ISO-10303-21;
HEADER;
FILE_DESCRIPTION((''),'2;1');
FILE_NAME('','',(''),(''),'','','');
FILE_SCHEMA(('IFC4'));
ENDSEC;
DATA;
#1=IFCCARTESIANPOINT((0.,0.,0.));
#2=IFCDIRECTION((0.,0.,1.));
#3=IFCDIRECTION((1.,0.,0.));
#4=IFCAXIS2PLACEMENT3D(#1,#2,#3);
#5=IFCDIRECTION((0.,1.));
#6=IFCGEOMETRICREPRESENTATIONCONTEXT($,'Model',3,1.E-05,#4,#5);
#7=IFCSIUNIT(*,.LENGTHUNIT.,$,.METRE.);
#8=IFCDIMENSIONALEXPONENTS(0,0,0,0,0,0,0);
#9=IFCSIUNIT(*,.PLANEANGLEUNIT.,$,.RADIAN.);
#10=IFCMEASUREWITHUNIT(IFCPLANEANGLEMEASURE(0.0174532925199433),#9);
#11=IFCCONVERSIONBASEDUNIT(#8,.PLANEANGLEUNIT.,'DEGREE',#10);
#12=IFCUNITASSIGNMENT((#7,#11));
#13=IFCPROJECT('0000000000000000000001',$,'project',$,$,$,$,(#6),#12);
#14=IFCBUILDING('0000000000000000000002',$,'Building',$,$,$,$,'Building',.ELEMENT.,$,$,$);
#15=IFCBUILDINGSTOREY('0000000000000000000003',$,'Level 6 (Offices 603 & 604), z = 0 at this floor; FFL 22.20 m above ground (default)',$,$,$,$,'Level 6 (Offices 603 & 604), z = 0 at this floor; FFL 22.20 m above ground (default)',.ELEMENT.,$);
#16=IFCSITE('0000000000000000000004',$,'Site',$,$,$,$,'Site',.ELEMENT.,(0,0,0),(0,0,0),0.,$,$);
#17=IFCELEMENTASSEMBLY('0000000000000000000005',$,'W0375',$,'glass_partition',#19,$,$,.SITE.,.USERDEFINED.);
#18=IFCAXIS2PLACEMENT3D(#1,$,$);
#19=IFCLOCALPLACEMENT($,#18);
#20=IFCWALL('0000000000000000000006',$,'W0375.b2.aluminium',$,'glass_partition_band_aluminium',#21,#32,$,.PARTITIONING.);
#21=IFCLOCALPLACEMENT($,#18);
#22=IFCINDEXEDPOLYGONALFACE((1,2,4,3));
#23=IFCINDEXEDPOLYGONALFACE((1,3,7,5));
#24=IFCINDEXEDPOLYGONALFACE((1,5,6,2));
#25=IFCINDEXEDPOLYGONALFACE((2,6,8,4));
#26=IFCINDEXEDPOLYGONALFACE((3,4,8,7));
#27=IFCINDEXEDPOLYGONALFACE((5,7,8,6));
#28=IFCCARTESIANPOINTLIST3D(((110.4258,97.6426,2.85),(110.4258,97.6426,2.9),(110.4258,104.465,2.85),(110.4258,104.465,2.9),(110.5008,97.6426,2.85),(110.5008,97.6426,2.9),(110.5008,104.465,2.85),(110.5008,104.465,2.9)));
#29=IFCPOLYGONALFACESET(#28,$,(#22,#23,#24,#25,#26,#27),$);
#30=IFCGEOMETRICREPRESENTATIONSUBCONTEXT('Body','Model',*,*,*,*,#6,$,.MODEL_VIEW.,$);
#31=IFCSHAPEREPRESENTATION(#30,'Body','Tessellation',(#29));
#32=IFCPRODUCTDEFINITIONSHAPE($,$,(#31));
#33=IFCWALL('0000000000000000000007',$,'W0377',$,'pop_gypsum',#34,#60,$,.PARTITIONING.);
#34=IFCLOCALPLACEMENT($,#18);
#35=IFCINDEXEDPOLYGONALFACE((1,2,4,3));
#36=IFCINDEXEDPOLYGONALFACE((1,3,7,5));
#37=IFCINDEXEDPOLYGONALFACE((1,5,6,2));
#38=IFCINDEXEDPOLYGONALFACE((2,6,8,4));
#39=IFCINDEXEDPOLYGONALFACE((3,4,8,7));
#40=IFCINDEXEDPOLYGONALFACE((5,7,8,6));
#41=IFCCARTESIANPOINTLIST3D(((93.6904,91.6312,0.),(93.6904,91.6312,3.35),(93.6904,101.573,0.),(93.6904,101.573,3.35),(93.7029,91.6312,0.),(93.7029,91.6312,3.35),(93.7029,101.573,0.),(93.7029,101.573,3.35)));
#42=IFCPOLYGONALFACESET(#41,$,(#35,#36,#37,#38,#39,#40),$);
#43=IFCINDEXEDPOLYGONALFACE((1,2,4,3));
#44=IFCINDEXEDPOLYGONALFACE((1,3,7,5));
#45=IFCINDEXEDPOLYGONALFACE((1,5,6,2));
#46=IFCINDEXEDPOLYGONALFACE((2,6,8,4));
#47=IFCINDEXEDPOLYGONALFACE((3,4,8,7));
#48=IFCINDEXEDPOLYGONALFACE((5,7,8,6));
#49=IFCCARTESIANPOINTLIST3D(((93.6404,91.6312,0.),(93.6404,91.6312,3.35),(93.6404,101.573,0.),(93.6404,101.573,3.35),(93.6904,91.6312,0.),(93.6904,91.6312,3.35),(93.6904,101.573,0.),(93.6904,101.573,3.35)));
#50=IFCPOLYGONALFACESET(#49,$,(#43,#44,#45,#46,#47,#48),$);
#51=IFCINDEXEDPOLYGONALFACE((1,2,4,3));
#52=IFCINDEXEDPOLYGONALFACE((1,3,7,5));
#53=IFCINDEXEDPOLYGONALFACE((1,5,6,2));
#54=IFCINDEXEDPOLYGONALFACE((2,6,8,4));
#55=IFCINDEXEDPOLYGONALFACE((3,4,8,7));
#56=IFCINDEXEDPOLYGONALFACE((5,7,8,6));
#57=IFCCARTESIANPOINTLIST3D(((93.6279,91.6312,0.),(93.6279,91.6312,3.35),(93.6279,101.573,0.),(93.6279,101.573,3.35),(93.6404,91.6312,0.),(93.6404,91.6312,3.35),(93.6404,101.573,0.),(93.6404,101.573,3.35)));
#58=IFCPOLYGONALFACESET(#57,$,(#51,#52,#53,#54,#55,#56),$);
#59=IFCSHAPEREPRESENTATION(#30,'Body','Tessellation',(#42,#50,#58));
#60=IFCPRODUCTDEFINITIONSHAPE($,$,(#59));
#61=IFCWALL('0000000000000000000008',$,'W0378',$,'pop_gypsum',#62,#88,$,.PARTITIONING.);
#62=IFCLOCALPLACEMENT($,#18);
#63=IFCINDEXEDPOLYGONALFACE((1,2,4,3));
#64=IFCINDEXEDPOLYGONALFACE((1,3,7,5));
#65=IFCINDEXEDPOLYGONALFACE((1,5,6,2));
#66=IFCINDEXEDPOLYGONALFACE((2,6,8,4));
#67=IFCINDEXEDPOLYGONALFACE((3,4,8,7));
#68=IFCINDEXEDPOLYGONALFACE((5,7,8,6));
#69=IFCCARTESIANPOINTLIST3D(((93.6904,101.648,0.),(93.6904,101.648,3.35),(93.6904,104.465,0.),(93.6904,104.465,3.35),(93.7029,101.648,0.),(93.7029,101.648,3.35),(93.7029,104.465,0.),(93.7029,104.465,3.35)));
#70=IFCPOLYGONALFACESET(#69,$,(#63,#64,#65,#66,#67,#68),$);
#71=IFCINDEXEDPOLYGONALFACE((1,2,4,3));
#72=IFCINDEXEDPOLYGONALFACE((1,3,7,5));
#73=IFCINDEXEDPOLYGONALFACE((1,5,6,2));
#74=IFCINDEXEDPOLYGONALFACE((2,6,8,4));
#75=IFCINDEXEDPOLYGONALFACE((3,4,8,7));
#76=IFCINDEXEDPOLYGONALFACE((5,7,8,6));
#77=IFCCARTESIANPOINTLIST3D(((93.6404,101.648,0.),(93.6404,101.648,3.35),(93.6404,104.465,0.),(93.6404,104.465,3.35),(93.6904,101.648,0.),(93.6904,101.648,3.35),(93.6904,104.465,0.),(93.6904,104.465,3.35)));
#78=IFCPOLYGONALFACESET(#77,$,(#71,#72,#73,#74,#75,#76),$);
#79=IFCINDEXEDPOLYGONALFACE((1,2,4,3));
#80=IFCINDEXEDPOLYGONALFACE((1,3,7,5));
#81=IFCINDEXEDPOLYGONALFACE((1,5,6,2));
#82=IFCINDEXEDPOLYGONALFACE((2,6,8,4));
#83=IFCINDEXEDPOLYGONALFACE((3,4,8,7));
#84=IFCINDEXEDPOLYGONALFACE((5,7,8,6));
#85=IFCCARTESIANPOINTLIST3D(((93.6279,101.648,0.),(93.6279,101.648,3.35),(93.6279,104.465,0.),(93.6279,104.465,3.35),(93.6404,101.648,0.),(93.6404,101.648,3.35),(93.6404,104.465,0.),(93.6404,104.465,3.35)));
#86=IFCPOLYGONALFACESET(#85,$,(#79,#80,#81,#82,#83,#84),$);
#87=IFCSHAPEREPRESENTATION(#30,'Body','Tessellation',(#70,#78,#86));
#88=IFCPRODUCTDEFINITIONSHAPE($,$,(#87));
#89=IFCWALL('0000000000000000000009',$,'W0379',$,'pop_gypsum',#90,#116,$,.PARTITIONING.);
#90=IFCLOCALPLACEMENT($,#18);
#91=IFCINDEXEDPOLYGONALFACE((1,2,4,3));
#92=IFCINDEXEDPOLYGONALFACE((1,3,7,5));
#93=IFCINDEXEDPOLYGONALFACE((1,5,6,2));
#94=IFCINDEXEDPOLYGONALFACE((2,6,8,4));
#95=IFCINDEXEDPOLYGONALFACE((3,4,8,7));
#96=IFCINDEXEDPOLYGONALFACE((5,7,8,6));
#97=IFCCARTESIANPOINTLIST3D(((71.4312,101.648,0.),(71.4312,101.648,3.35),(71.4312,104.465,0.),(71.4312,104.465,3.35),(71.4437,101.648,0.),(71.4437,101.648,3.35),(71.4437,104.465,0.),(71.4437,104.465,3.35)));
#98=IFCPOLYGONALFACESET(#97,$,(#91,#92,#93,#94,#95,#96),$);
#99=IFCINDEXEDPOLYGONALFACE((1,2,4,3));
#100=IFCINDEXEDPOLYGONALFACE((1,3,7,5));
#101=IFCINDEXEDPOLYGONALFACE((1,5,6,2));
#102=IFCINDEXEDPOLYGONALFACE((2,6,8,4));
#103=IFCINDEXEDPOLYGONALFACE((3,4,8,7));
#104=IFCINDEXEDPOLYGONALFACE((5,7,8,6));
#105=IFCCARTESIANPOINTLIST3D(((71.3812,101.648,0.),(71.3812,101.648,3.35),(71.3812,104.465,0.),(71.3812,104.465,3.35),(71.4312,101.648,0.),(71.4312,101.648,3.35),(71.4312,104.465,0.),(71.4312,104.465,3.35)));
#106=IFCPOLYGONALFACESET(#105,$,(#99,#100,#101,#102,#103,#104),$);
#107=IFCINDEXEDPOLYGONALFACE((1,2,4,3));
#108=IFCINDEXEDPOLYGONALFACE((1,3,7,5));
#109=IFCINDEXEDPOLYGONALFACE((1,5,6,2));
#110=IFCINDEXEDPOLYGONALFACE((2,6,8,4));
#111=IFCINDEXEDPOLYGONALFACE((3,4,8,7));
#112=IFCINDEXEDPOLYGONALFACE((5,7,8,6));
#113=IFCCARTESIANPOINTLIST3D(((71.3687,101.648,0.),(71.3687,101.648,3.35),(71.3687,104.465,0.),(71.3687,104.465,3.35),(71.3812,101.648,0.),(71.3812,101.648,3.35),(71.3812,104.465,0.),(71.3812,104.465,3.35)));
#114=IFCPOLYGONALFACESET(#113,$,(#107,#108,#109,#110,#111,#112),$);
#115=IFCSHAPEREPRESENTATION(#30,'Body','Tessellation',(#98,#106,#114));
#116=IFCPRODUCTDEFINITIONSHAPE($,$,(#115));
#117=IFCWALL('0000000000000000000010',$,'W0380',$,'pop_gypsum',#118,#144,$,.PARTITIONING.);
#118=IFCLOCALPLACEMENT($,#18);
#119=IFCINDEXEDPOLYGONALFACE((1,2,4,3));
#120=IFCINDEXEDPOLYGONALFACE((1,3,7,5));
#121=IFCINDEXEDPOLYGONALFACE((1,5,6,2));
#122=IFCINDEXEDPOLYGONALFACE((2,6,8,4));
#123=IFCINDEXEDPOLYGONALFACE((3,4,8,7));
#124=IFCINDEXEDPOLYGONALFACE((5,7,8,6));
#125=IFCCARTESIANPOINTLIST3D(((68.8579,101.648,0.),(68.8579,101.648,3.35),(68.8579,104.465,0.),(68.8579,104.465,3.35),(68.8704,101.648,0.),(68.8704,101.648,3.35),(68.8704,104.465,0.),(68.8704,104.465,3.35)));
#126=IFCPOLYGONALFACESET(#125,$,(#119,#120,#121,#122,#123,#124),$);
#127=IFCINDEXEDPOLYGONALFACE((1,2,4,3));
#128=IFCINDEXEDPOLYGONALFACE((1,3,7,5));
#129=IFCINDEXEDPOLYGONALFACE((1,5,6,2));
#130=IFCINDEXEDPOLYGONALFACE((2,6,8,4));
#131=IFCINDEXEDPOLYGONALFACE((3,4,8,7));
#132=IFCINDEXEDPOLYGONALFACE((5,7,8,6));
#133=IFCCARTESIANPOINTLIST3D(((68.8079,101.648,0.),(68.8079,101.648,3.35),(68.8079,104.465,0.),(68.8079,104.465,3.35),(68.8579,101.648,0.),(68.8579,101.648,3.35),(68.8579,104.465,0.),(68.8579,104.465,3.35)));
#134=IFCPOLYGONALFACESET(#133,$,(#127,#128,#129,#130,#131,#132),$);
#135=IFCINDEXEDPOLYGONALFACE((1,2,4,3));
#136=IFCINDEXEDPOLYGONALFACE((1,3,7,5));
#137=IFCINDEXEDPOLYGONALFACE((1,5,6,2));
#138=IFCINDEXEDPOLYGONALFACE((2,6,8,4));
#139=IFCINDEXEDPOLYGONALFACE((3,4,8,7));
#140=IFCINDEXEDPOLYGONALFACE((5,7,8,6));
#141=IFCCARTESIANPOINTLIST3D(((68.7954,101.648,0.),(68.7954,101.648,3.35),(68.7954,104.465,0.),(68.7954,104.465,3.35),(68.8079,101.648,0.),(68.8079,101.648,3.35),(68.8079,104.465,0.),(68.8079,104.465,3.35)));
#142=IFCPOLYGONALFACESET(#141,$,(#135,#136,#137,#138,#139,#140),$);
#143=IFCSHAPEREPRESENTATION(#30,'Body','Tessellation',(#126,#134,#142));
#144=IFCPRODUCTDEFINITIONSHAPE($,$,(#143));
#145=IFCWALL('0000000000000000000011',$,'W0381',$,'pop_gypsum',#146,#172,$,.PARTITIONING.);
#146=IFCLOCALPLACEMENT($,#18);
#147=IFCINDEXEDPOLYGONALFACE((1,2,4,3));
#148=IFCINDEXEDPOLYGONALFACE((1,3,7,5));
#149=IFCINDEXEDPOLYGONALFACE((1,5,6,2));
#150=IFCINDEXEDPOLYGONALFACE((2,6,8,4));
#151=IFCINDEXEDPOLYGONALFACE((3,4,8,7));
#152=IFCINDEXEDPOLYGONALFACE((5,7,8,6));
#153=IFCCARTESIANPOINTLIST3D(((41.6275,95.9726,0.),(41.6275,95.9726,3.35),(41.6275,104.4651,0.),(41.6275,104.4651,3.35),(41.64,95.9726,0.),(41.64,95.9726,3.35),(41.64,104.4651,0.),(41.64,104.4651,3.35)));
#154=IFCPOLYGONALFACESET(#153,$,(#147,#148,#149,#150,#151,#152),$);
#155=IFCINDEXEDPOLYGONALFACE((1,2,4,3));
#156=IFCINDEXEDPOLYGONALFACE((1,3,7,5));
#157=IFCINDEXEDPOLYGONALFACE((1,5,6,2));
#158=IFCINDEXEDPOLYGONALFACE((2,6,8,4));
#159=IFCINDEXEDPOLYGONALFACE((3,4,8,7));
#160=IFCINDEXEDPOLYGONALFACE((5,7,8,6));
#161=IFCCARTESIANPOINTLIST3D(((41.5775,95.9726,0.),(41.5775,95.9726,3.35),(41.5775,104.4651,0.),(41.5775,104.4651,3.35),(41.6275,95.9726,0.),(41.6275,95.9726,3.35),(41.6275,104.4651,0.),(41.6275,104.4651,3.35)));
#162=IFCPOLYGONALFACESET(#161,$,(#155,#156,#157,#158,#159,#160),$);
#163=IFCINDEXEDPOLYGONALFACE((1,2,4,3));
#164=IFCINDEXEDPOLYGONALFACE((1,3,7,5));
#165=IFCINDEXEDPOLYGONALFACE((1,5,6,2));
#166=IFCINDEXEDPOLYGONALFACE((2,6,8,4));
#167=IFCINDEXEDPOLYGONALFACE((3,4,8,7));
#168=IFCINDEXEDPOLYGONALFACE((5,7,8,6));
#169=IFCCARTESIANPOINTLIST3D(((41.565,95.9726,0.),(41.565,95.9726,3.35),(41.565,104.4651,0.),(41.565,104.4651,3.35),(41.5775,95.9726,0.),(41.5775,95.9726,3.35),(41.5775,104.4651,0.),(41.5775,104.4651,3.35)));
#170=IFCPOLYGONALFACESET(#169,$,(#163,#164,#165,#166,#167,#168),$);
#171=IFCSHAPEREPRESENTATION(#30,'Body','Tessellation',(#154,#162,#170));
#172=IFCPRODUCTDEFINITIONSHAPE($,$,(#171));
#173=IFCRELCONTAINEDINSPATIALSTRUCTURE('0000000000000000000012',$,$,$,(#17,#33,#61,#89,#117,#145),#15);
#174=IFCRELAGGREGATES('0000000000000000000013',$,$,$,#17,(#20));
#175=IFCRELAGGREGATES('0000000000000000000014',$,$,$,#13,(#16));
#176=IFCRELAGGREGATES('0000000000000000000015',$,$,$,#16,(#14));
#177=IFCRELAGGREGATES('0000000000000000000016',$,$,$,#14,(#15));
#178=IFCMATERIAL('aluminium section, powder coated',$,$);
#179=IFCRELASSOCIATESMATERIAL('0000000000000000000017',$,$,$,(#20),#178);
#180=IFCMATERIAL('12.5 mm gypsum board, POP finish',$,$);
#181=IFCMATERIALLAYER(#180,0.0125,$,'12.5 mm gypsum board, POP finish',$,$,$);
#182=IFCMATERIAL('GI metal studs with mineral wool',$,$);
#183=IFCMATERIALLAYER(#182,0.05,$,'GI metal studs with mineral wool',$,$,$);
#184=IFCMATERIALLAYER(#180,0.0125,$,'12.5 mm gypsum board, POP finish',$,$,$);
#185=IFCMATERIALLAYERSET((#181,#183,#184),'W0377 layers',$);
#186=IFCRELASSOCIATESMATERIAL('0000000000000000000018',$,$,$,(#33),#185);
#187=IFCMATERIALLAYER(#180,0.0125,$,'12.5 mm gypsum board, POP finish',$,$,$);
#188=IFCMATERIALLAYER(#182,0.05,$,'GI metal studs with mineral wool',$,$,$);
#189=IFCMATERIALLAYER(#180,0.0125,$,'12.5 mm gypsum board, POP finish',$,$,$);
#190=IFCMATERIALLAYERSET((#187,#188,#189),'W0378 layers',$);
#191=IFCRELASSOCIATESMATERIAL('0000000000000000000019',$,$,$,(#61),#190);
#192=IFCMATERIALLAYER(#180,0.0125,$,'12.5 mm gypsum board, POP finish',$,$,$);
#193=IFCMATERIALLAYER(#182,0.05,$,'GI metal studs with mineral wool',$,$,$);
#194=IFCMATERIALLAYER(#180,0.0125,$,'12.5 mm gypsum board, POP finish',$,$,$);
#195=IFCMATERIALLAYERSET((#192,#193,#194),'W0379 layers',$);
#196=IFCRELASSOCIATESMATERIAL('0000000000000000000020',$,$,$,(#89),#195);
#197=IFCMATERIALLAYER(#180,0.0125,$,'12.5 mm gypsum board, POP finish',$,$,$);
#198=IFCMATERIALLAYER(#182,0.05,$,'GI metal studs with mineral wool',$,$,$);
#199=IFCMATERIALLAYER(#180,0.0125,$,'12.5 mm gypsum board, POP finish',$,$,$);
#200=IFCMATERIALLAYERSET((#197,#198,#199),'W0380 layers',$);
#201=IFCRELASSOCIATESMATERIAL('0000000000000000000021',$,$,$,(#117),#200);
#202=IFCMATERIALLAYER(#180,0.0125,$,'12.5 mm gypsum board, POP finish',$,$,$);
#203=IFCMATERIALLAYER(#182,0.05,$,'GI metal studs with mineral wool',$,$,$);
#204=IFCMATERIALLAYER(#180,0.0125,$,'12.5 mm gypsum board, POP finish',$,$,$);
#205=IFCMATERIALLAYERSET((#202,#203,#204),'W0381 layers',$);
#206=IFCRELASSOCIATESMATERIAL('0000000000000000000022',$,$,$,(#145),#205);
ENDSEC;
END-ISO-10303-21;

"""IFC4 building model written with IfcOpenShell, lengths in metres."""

from ifc_helpers import new_model, entity, si_unit, converted_unit, direction, frame, frame_2d, origin_with_axes, place, context, subcontext, project, spatial, rectangle, extrude, material, layer, layer_set, layer_usage, element, aggregate, save


model = new_model("IFC4")

# Units and contexts
model_context = context("Model", 3, precision=1e-05, world=origin_with_axes(), true_north=direction((0.0, 1.0)))
body_context = subcontext(model_context, "Body", "Model", "MODEL_VIEW")
ifc_project = project(units=[si_unit("LENGTHUNIT", "METRE"), converted_unit("PLANEANGLEUNIT", "DEGREE", entity("IfcPlaneAngleMeasure", 0.0174532925199433), si_unit("PLANEANGLEUNIT", "RADIAN"), dimensions=[0, 0, 0, 0, 0, 0, 0])], contexts=[model_context])

# Site, building, storey
site = spatial("IfcSite", under=ifc_project, Name="Site", LongName="Site", CompositionType="ELEMENT", RefLatitude=(0, 0, 0), RefLongitude=(0, 0, 0), RefElevation=0.0)
building = spatial("IfcBuilding", under=site, Name="Building", LongName="Building", CompositionType="ELEMENT")
storey = spatial("IfcBuildingStorey", under=building, Name="Level 6 (Offices 603 & 604), z = 0 at this floor; FFL 22.20 m above ground (default)", LongName="Level 6 (Offices 603 & 604), z = 0 at this floor; FFL 22.20 m above ground (default)", CompositionType="ELEMENT")

# Element assembly, wall
assembly_1 = element("IfcElementAssembly", 1, inside=storey, Name="W0375", ObjectType="glass_partition", AssemblyPlace="SITE", PredefinedType="USERDEFINED")
ifc_material_1 = material(Name="aluminium section, powder coated")
placement = place(None, origin_with_axes())
wall_1 = element("IfcWall", 2, at=placement, material=ifc_material_1, Name="W0375.b2.aluminium", ObjectType="glass_partition_band_aluminium", PredefinedType="PARTITIONING", context=body_context, shape_type="SweptSolid", body=[
    extrude(rectangle(XDim=6.8224, YDim=0.075, at=frame_2d((0.0, 0.0), x_axis=(0.0, 1.0))), frame((110.4633, 101.0538, 2.85), z_axis=(0.0, 0.0, 1.0), x_axis=(1.0, 0.0, 0.0)), (0.0, 0.0, 1.0), 0.05),
])
aggregate(assembly_1, [wall_1])

# Walls
ifc_material_2 = material(Name="12.5 mm gypsum board, POP finish")
ifc_layer_1 = layer(ifc_material_2, 0.0125, Name="12.5 mm gypsum board, POP finish")
ifc_material_3 = material(Name="GI metal studs with mineral wool")
ifc_layer_2 = layer(ifc_material_3, 0.05, Name="GI metal studs with mineral wool")
ifc_layer_3 = layer(ifc_material_2, 0.0125, Name="12.5 mm gypsum board, POP finish")
ifc_layer_set_1 = layer_set([ifc_layer_1, ifc_layer_2, ifc_layer_3], Name="W0377 layers")
ifc_layer_usage_1 = layer_usage(ifc_layer_set_1, "AXIS2", "POSITIVE", -0.0375)
element("IfcWall", 3, at=placement, inside=storey, material=ifc_layer_usage_1, Name="W0377", ObjectType="pop_gypsum", PredefinedType="PARTITIONING", context=body_context, shape_type="SweptSolid", body=[
    extrude(rectangle(XDim=9.9418, YDim=0.0125, at=frame_2d((0.0, 0.0), x_axis=(0.0, 1.0))), frame((93.6967, 96.6021, 0.0), z_axis=(0.0, 0.0, 1.0), x_axis=(1.0, 0.0, 0.0)), (0.0, 0.0, 1.0), 3.35),
    extrude(rectangle(XDim=9.9418, YDim=0.05, at=frame_2d((-0.0312, 0.0), x_axis=(0.0, 1.0))), frame((93.6967, 96.6021, 0.0), z_axis=(0.0, 0.0, 1.0), x_axis=(1.0, 0.0, 0.0)), (0.0, 0.0, 1.0), 3.35),
    extrude(rectangle(XDim=9.9418, YDim=0.0125, at=frame_2d((-0.0625, 0.0), x_axis=(0.0, 1.0))), frame((93.6967, 96.6021, 0.0), z_axis=(0.0, 0.0, 1.0), x_axis=(1.0, 0.0, 0.0)), (0.0, 0.0, 1.0), 3.35),
])
ifc_layer_4 = layer(ifc_material_2, 0.0125, Name="12.5 mm gypsum board, POP finish")
ifc_layer_5 = layer(ifc_material_3, 0.05, Name="GI metal studs with mineral wool")
ifc_layer_6 = layer(ifc_material_2, 0.0125, Name="12.5 mm gypsum board, POP finish")
ifc_layer_set_2 = layer_set([ifc_layer_4, ifc_layer_5, ifc_layer_6], Name="W0378 layers")
ifc_layer_usage_2 = layer_usage(ifc_layer_set_2, "AXIS2", "POSITIVE", -0.0375)
element("IfcWall", 4, at=placement, inside=storey, material=ifc_layer_usage_2, Name="W0378", ObjectType="pop_gypsum", PredefinedType="PARTITIONING", context=body_context, shape_type="SweptSolid", body=[
    extrude(rectangle(XDim=2.817, YDim=0.0125, at=frame_2d((0.0, 0.0), x_axis=(0.0, 1.0))), frame((93.6967, 103.0565, 0.0), z_axis=(0.0, 0.0, 1.0), x_axis=(1.0, 0.0, 0.0)), (0.0, 0.0, 1.0), 3.35),
    extrude(rectangle(XDim=2.817, YDim=0.05, at=frame_2d((-0.0312, 0.0), x_axis=(0.0, 1.0))), frame((93.6967, 103.0565, 0.0), z_axis=(0.0, 0.0, 1.0), x_axis=(1.0, 0.0, 0.0)), (0.0, 0.0, 1.0), 3.35),
    extrude(rectangle(XDim=2.817, YDim=0.0125, at=frame_2d((-0.0625, 0.0), x_axis=(0.0, 1.0))), frame((93.6967, 103.0565, 0.0), z_axis=(0.0, 0.0, 1.0), x_axis=(1.0, 0.0, 0.0)), (0.0, 0.0, 1.0), 3.35),
])
ifc_layer_7 = layer(ifc_material_2, 0.0125, Name="12.5 mm gypsum board, POP finish")
ifc_layer_8 = layer(ifc_material_3, 0.05, Name="GI metal studs with mineral wool")
ifc_layer_9 = layer(ifc_material_2, 0.0125, Name="12.5 mm gypsum board, POP finish")
ifc_layer_set_3 = layer_set([ifc_layer_7, ifc_layer_8, ifc_layer_9], Name="W0379 layers")
ifc_layer_usage_3 = layer_usage(ifc_layer_set_3, "AXIS2", "POSITIVE", -0.0375)
element("IfcWall", 5, at=placement, inside=storey, material=ifc_layer_usage_3, Name="W0379", ObjectType="pop_gypsum", PredefinedType="PARTITIONING", context=body_context, shape_type="SweptSolid", body=[
    extrude(rectangle(XDim=2.817, YDim=0.0125, at=frame_2d((0.0, 0.0), x_axis=(0.0, 1.0))), frame((71.4374, 103.0565, 0.0), z_axis=(0.0, 0.0, 1.0), x_axis=(1.0, 0.0, 0.0)), (0.0, 0.0, 1.0), 3.35),
    extrude(rectangle(XDim=2.817, YDim=0.05, at=frame_2d((-0.0312, 0.0), x_axis=(0.0, 1.0))), frame((71.4374, 103.0565, 0.0), z_axis=(0.0, 0.0, 1.0), x_axis=(1.0, 0.0, 0.0)), (0.0, 0.0, 1.0), 3.35),
    extrude(rectangle(XDim=2.817, YDim=0.0125, at=frame_2d((-0.0625, 0.0), x_axis=(0.0, 1.0))), frame((71.4374, 103.0565, 0.0), z_axis=(0.0, 0.0, 1.0), x_axis=(1.0, 0.0, 0.0)), (0.0, 0.0, 1.0), 3.35),
])
ifc_layer_10 = layer(ifc_material_2, 0.0125, Name="12.5 mm gypsum board, POP finish")
ifc_layer_11 = layer(ifc_material_3, 0.05, Name="GI metal studs with mineral wool")
ifc_layer_12 = layer(ifc_material_2, 0.0125, Name="12.5 mm gypsum board, POP finish")
ifc_layer_set_4 = layer_set([ifc_layer_10, ifc_layer_11, ifc_layer_12], Name="W0380 layers")
ifc_layer_usage_4 = layer_usage(ifc_layer_set_4, "AXIS2", "POSITIVE", -0.0375)
element("IfcWall", 6, at=placement, inside=storey, material=ifc_layer_usage_4, Name="W0380", ObjectType="pop_gypsum", PredefinedType="PARTITIONING", context=body_context, shape_type="SweptSolid", body=[
    extrude(rectangle(XDim=2.817, YDim=0.0125, at=frame_2d((0.0, 0.0), x_axis=(0.0, 1.0))), frame((68.8641, 103.0565, 0.0), z_axis=(0.0, 0.0, 1.0), x_axis=(1.0, 0.0, 0.0)), (0.0, 0.0, 1.0), 3.35),
    extrude(rectangle(XDim=2.817, YDim=0.05, at=frame_2d((-0.0312, 0.0), x_axis=(0.0, 1.0))), frame((68.8641, 103.0565, 0.0), z_axis=(0.0, 0.0, 1.0), x_axis=(1.0, 0.0, 0.0)), (0.0, 0.0, 1.0), 3.35),
    extrude(rectangle(XDim=2.817, YDim=0.0125, at=frame_2d((-0.0625, 0.0), x_axis=(0.0, 1.0))), frame((68.8641, 103.0565, 0.0), z_axis=(0.0, 0.0, 1.0), x_axis=(1.0, 0.0, 0.0)), (0.0, 0.0, 1.0), 3.35),
])
ifc_layer_13 = layer(ifc_material_2, 0.0125, Name="12.5 mm gypsum board, POP finish")
ifc_layer_14 = layer(ifc_material_3, 0.05, Name="GI metal studs with mineral wool")
ifc_layer_15 = layer(ifc_material_2, 0.0125, Name="12.5 mm gypsum board, POP finish")
ifc_layer_set_5 = layer_set([ifc_layer_13, ifc_layer_14, ifc_layer_15], Name="W0381 layers")
ifc_layer_usage_5 = layer_usage(ifc_layer_set_5, "AXIS2", "POSITIVE", -0.0375)
element("IfcWall", 7, at=placement, inside=storey, material=ifc_layer_usage_5, Name="W0381", ObjectType="pop_gypsum", PredefinedType="PARTITIONING", context=body_context, shape_type="SweptSolid", body=[
    extrude(rectangle(XDim=8.4925, YDim=0.0125, at=frame_2d((0.0, 0.0), x_axis=(0.0, 1.0))), frame((41.6337, 100.2189, 0.0), z_axis=(0.0, 0.0, 1.0), x_axis=(1.0, 0.0, 0.0)), (0.0, 0.0, 1.0), 3.35),
    extrude(rectangle(XDim=8.4925, YDim=0.05, at=frame_2d((-0.0312, 0.0), x_axis=(0.0, 1.0))), frame((41.6337, 100.2189, 0.0), z_axis=(0.0, 0.0, 1.0), x_axis=(1.0, 0.0, 0.0)), (0.0, 0.0, 1.0), 3.35),
    extrude(rectangle(XDim=8.4925, YDim=0.0125, at=frame_2d((-0.0625, 0.0), x_axis=(0.0, 1.0))), frame((41.6337, 100.2189, 0.0), z_axis=(0.0, 0.0, 1.0), x_axis=(1.0, 0.0, 0.0)), (0.0, 0.0, 1.0), 3.35),
])

save(model, "model.ifc")
